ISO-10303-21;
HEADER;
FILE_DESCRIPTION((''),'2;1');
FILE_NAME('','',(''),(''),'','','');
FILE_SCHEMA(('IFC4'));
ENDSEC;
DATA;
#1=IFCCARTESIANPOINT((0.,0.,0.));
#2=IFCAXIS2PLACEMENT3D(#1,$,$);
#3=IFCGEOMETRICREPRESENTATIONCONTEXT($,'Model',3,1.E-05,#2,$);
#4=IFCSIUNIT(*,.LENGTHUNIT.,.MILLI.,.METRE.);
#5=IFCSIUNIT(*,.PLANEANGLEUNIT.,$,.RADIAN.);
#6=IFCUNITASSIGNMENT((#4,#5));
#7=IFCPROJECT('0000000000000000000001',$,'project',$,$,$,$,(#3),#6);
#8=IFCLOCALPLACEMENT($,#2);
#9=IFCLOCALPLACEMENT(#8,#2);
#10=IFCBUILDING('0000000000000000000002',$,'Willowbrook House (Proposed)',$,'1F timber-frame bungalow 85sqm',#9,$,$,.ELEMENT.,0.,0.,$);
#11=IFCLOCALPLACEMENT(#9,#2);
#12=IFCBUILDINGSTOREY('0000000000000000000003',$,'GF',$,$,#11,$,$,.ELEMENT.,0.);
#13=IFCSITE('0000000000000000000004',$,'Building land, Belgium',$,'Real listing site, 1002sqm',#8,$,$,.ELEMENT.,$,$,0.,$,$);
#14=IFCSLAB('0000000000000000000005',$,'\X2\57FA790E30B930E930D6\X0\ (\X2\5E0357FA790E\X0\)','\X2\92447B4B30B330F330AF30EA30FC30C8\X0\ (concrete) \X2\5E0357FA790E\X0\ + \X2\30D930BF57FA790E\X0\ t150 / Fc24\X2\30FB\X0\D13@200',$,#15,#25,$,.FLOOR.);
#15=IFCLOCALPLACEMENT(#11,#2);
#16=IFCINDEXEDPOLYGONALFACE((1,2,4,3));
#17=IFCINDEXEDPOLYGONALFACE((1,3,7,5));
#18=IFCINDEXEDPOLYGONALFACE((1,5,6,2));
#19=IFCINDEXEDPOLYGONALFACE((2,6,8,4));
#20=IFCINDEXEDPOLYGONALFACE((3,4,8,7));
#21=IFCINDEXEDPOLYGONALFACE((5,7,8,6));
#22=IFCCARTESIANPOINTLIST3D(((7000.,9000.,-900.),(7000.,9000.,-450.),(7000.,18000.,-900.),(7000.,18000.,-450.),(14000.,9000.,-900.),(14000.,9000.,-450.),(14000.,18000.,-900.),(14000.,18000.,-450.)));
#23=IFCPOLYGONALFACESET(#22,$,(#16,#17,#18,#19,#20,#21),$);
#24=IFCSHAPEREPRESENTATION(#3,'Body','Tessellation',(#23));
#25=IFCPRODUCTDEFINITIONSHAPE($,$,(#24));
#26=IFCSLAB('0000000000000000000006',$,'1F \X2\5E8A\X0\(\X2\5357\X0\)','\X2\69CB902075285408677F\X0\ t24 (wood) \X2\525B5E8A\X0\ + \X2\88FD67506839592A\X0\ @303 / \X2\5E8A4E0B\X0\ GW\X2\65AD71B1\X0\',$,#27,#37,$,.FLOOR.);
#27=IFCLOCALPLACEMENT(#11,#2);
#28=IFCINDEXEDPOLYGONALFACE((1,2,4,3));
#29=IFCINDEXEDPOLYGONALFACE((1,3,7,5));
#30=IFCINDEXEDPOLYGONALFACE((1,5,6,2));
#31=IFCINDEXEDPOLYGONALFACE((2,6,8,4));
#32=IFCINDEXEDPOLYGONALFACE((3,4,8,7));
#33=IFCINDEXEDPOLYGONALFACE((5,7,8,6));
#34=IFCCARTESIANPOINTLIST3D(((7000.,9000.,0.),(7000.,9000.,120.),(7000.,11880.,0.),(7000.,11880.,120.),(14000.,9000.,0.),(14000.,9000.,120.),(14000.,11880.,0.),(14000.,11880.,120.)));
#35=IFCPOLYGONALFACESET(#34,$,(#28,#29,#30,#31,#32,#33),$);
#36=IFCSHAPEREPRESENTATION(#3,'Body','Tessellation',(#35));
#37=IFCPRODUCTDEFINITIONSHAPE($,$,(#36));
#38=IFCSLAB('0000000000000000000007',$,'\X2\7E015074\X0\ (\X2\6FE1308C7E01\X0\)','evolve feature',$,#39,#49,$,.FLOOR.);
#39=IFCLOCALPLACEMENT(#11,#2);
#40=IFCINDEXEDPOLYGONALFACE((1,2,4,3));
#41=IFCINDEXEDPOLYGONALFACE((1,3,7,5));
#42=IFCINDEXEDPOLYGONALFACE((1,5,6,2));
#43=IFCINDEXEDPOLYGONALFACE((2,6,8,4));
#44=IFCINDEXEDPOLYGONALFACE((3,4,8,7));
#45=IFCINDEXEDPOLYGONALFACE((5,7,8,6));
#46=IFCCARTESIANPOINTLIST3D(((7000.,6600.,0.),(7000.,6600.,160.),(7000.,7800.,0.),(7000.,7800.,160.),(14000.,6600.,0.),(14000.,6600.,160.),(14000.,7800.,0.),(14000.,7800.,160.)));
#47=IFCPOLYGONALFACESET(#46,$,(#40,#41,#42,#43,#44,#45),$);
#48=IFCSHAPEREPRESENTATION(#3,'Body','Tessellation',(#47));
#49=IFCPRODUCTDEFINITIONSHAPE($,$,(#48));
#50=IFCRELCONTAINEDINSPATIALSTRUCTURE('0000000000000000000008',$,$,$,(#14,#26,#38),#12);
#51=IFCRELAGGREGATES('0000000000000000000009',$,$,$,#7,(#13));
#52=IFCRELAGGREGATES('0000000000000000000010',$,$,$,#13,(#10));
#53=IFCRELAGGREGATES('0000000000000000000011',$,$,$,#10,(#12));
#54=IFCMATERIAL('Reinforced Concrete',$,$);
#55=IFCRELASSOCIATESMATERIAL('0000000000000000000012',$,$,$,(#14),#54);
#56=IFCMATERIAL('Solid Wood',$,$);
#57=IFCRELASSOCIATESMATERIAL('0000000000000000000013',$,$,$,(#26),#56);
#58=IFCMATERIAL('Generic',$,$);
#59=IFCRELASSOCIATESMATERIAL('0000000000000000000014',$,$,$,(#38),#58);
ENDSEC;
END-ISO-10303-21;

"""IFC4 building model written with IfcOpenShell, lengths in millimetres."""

from ifc_helpers import new_model, si_unit, frame, frame_2d, origin, place, context, project, spatial, rectangle, extrude, material, element, save


model = new_model("IFC4")

# Units and contexts
model_context = context("Model", 3, precision=1e-05, world=origin())
ifc_project = project(units=[si_unit("LENGTHUNIT", "METRE", prefix="MILLI"), si_unit("PLANEANGLEUNIT", "RADIAN")], contexts=[model_context])

# Site, building, storey
site_placement = place(None, origin())
site = spatial("IfcSite", under=ifc_project, at=site_placement, Name="Building land, Belgium", ObjectType="Real listing site, 1002sqm", CompositionType="ELEMENT", RefElevation=0.0)
building_placement = place(site_placement, origin())
building = spatial("IfcBuilding", under=site, at=building_placement, Name="Willowbrook House (Proposed)", ObjectType="1F timber-frame bungalow 85sqm", CompositionType="ELEMENT", ElevationOfRefHeight=0.0, ElevationOfTerrain=0.0)
storey_placement = place(building_placement, origin())
storey = spatial("IfcBuildingStorey", under=building, at=storey_placement, Name="GF", CompositionType="ELEMENT", Elevation=0.0)

# Slabs
ifc_material_1 = material(Name="Reinforced Concrete")
slab_1_placement = place(storey_placement, frame((3500.0, 4500.0, -450.0)))
element("IfcSlab", 1, at=slab_1_placement, inside=storey, material=ifc_material_1, Name="基礎スラブ (布基礎)", Description="鉄筋コンクリート (concrete) 布基礎 + ベタ基礎 t150 / Fc24・D13@200", PredefinedType="FLOOR", context=model_context, shape_type="SweptSolid", body=[
    extrude(rectangle(XDim=7000.0, YDim=9000.0, at=frame_2d((3500.0, 4500.0))), frame((3500.0, 4500.0, -450.0)), (0.0, 0.0, 1.0), 450.0),
])
ifc_material_2 = material(Name="Solid Wood")
slab_2_placement = place(storey_placement, frame((3500.0, 4500.0, 0.0)))
element("IfcSlab", 2, at=slab_2_placement, inside=storey, material=ifc_material_2, Name="1F 床(南)", Description="構造用合板 t24 (wood) 剛床 + 製材根太 @303 / 床下 GW断熱", PredefinedType="FLOOR", context=model_context, shape_type="SweptSolid", body=[
    extrude(rectangle(XDim=7000.0, YDim=2880.0, at=frame_2d((3500.0, 1440.0))), frame((3500.0, 4500.0, 0.0)), (0.0, 0.0, 1.0), 120.0),
])
ifc_material_3 = material(Name="Generic")
slab_3_placement = place(storey_placement, frame((3500.0, 3300.0, 0.0)))
element("IfcSlab", 3, at=slab_3_placement, inside=storey, material=ifc_material_3, Name="縁側 (濡れ縁)", Description="evolve feature", PredefinedType="FLOOR", context=model_context, shape_type="SweptSolid", body=[
    extrude(rectangle(XDim=7000.0, YDim=1200.0, at=frame_2d((3500.0, 600.0))), frame((3500.0, 3300.0, 0.0)), (0.0, 0.0, 1.0), 160.0),
])

save(model, "model.ifc")
